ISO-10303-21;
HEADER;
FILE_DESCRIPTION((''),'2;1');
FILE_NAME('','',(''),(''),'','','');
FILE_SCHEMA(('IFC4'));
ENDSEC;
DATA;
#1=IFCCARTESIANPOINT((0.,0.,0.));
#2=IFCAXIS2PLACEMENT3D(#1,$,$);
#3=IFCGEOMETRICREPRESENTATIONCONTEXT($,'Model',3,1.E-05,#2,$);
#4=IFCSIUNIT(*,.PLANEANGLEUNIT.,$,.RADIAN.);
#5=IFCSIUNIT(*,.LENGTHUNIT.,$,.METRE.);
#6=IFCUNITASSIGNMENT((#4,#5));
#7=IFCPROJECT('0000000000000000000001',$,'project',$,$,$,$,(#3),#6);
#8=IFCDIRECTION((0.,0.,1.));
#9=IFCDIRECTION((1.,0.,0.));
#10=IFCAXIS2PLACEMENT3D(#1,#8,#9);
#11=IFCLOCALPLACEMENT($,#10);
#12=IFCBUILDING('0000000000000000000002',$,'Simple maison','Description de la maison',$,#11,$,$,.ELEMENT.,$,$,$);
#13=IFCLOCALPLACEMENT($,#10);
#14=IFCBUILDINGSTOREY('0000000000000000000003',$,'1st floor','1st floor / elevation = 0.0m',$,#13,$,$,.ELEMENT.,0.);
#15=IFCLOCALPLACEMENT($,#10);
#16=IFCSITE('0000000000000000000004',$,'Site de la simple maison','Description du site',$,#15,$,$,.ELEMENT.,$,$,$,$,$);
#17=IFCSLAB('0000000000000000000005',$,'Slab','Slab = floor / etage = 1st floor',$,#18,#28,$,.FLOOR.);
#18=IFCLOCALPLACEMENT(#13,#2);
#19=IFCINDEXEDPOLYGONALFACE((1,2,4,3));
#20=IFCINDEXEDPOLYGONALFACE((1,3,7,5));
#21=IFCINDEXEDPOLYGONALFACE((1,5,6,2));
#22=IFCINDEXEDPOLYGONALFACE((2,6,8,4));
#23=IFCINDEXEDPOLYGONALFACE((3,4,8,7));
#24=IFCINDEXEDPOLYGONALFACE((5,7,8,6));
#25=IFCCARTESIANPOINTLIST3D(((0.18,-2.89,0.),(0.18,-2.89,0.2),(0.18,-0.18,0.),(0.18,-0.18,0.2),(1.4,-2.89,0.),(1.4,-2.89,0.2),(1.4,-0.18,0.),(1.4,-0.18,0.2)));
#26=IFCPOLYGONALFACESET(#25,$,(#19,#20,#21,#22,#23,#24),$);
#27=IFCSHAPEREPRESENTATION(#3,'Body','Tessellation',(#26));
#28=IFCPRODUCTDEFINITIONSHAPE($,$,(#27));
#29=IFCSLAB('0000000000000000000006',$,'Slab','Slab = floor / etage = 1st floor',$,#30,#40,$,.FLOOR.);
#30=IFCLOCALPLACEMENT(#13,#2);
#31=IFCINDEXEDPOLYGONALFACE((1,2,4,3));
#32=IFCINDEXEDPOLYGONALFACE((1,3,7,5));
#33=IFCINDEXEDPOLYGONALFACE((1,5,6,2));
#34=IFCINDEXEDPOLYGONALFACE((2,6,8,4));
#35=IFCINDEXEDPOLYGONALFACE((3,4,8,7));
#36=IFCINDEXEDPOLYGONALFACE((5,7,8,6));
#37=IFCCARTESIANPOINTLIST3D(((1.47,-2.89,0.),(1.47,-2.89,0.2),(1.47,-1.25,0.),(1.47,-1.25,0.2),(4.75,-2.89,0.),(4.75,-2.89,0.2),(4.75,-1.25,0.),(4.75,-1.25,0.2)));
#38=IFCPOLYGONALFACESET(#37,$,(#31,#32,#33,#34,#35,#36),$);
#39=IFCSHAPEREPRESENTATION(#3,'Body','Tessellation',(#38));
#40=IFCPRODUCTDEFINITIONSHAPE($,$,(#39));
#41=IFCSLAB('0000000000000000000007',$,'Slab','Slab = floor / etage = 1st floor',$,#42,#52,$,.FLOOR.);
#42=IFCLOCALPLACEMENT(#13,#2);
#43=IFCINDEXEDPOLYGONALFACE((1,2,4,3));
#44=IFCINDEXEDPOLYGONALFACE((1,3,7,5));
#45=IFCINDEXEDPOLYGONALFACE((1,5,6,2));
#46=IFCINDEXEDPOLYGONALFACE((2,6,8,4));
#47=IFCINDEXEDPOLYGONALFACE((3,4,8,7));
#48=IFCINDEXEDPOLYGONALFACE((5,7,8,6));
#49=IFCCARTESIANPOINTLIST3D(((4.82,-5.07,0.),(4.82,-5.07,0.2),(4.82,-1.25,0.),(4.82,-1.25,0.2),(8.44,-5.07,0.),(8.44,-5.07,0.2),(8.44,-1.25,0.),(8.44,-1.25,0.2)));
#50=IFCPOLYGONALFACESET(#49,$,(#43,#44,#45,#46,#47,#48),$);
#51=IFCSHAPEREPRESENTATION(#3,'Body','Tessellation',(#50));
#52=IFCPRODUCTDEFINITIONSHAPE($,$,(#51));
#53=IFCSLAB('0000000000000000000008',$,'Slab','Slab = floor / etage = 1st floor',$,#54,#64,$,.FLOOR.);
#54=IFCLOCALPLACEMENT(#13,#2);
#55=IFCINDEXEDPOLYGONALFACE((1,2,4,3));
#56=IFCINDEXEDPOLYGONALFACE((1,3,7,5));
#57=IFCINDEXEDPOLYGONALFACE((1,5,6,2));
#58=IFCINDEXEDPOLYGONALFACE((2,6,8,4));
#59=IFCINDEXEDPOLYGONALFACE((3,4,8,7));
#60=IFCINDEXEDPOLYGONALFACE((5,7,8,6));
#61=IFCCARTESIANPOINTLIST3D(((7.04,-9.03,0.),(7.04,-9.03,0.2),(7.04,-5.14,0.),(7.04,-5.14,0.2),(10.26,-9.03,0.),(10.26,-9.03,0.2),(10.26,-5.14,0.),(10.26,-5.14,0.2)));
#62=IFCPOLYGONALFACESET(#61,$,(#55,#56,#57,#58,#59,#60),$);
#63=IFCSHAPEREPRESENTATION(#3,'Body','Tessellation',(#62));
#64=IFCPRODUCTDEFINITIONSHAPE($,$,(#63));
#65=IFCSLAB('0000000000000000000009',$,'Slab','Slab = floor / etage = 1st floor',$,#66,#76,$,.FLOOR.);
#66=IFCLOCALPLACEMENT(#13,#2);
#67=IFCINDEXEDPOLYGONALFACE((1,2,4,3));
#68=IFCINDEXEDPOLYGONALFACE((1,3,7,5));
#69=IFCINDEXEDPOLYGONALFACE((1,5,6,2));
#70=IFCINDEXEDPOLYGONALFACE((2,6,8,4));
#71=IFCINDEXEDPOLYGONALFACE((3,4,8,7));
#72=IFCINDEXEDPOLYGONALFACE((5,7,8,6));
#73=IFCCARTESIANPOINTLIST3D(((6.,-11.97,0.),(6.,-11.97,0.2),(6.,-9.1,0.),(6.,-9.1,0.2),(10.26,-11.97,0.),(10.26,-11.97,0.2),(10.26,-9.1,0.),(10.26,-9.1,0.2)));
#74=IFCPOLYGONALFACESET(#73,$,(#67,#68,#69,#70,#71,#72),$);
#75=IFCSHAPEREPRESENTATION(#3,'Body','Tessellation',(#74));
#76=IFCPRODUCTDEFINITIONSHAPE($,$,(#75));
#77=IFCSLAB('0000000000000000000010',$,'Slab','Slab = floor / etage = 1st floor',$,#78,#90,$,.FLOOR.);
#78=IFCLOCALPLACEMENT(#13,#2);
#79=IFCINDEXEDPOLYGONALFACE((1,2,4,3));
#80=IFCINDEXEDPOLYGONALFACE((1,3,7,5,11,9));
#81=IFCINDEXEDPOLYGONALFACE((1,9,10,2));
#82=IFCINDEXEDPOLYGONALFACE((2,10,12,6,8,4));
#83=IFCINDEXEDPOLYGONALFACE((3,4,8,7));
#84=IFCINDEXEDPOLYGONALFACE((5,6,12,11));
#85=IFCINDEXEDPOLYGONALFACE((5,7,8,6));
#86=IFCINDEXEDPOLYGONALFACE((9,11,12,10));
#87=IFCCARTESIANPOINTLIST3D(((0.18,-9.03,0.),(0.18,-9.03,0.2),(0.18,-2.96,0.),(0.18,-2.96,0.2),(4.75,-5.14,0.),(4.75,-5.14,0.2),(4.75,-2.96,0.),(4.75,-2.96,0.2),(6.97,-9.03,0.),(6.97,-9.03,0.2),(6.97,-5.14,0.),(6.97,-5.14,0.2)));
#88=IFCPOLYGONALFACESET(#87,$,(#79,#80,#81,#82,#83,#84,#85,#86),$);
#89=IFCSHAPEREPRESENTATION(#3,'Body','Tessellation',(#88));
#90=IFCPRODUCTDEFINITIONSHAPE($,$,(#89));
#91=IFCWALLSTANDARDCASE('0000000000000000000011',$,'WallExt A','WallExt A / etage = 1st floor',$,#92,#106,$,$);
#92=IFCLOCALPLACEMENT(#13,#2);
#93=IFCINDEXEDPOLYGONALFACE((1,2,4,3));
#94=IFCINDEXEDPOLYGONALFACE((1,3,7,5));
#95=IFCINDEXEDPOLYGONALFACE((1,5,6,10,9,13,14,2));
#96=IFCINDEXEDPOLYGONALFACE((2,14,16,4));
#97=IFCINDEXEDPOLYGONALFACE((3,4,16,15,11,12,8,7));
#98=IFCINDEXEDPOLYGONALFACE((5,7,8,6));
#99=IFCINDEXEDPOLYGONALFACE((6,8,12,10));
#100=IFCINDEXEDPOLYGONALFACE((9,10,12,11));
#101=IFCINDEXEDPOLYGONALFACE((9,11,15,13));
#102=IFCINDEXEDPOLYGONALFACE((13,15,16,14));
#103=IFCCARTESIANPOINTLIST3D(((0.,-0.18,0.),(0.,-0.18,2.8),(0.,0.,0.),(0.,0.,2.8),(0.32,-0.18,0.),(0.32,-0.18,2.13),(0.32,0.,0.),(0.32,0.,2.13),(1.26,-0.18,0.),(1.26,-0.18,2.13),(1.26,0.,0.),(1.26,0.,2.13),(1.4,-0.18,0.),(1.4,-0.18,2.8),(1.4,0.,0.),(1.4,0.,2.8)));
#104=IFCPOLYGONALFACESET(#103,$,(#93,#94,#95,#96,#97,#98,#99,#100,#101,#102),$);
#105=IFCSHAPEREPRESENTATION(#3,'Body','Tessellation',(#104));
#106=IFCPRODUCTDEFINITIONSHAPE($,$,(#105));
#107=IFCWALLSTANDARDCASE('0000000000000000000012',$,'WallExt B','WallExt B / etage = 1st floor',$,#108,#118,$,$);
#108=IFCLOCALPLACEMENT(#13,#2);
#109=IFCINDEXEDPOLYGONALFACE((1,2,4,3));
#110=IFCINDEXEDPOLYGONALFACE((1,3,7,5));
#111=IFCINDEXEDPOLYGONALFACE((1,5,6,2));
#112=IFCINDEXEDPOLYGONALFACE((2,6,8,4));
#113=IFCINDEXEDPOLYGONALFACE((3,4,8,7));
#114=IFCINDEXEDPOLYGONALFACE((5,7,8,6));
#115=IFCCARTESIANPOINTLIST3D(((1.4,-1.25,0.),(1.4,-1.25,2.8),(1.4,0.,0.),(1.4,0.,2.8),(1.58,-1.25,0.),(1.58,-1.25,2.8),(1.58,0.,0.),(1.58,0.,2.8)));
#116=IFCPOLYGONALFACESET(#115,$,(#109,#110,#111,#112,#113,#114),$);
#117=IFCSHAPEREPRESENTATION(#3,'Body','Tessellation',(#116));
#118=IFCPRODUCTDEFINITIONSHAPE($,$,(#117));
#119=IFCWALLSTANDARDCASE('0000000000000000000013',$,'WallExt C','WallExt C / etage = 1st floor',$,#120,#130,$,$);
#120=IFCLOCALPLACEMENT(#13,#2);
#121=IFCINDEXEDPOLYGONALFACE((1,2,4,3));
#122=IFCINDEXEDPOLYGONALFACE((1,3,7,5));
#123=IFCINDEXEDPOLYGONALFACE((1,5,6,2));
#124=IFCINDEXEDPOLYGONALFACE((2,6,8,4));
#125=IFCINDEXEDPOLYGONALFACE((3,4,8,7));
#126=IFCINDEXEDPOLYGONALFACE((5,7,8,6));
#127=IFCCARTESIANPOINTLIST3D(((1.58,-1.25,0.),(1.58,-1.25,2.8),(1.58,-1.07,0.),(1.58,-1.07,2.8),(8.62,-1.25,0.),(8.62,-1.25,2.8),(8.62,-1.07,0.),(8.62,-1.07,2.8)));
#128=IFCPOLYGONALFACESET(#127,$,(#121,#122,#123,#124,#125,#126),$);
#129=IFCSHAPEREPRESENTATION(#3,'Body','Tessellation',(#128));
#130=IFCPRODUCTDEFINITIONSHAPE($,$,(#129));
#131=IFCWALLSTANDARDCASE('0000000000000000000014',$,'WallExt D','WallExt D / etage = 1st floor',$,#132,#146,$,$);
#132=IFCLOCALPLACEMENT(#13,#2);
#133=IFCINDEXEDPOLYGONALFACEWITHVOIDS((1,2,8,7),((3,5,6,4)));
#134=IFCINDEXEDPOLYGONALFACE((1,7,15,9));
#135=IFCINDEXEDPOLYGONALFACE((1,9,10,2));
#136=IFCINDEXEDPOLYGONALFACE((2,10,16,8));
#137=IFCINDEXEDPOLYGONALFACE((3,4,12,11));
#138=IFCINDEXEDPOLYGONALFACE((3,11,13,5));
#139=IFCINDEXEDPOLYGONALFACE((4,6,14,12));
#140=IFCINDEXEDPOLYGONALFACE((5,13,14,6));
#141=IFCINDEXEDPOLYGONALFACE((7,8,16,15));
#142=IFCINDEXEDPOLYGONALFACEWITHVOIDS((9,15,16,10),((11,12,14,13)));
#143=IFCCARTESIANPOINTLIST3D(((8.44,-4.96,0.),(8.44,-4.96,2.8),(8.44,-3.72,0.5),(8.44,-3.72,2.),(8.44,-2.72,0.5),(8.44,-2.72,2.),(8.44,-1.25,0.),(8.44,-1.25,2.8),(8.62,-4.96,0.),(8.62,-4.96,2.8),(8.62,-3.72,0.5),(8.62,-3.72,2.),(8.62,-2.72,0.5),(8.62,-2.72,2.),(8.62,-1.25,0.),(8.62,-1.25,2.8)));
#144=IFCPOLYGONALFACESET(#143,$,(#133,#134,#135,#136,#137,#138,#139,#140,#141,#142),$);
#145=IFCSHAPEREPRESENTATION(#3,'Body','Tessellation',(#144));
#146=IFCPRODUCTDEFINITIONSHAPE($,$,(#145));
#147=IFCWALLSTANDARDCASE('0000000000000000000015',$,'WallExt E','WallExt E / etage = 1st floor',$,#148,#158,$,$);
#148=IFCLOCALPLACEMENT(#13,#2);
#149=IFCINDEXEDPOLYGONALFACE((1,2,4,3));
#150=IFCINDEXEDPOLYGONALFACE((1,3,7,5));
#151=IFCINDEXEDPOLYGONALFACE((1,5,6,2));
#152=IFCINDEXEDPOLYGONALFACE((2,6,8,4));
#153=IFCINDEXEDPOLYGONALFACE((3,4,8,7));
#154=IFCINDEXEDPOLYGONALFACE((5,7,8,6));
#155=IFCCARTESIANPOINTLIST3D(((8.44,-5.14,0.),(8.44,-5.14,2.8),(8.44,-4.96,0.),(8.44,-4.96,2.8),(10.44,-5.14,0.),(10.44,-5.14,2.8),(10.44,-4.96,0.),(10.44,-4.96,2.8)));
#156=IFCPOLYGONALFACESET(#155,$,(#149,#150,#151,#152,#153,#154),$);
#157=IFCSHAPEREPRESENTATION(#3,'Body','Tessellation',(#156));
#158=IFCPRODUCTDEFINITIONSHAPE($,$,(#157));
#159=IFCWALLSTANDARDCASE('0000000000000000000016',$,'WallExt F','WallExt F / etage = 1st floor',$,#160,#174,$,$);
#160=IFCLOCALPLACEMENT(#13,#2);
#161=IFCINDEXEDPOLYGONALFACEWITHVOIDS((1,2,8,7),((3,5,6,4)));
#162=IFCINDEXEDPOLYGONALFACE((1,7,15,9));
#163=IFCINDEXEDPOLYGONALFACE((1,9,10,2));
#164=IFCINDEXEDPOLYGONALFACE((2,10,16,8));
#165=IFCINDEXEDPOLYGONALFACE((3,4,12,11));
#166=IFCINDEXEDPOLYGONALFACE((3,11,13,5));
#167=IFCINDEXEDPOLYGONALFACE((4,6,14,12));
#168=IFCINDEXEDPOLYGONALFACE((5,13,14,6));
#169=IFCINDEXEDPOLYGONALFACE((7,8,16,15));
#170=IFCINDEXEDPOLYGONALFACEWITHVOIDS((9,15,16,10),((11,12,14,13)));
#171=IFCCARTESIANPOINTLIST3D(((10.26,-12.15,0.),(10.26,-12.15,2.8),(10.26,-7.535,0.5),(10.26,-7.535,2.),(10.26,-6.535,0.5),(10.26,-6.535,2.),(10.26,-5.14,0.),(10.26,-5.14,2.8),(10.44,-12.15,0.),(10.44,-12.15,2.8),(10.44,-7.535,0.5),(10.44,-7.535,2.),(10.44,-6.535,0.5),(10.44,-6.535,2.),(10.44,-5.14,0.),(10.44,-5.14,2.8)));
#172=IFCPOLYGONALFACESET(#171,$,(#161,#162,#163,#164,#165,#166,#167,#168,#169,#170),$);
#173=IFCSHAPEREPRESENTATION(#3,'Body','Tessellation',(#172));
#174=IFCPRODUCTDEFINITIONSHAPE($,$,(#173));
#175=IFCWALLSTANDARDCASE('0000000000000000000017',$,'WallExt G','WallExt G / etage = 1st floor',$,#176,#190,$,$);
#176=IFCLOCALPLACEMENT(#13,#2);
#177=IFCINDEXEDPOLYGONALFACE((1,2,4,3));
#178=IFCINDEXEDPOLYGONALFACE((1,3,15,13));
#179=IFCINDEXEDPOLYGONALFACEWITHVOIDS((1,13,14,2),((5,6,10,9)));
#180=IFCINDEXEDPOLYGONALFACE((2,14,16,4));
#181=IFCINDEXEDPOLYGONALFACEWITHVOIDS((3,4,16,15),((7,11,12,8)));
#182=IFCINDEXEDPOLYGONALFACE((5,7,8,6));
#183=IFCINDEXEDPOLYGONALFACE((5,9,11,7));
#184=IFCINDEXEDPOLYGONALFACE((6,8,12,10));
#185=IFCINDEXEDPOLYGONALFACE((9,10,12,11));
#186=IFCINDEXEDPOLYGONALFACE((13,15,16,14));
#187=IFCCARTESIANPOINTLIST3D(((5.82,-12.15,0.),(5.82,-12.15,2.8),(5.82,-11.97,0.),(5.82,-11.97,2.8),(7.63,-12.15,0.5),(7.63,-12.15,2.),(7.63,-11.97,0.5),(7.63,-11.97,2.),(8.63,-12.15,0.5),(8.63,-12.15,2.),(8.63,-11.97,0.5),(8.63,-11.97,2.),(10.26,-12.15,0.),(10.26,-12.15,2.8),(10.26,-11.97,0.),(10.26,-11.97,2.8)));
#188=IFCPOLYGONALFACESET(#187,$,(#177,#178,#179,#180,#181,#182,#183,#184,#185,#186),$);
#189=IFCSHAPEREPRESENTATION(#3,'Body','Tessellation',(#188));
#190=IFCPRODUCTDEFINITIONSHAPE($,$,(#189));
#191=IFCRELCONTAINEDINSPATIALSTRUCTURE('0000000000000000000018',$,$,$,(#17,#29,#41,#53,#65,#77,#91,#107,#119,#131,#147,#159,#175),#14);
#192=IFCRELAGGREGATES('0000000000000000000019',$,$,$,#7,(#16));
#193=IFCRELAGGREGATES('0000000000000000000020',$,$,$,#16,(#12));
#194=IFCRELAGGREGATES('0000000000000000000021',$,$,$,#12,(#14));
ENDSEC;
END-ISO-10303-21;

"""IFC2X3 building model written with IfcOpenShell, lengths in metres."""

from ifc_helpers import new_model, si_unit, frame, origin, origin_with_axes, origin_2d_with_axis, place, context, project, spatial, polyline, rectangle, outline, extrude, element, save


model = new_model("IFC2X3")

# Units and contexts
model_context = context("Model", 3, precision=1e-05, world=origin())
ifc_project = project(units=[si_unit("PLANEANGLEUNIT", "RADIAN"), si_unit("LENGTHUNIT", "METRE")], contexts=[model_context])

# Site, building, storey
site_placement = place(None, origin_with_axes())
site = spatial("IfcSite", under=ifc_project, at=site_placement, Name="Site de la simple maison", Description="Description du site", CompositionType="ELEMENT")
building_placement = place(None, origin_with_axes())
building = spatial("IfcBuilding", under=site, at=building_placement, Name="Simple maison", Description="Description de la maison", CompositionType="ELEMENT")
storey_placement = place(None, origin_with_axes())
storey = spatial("IfcBuildingStorey", under=building, at=storey_placement, Name="1st floor", Description="1st floor / elevation = 0.0m", CompositionType="ELEMENT", Elevation=0.0)

# Slabs
slab_1_placement = place(storey_placement, origin_with_axes())
element("IfcSlab", 1, at=slab_1_placement, inside=storey, Name="Slab", Description="Slab = floor / etage = 1st floor", PredefinedType="FLOOR", context=model_context, shape_type="SweptSolid", body=[
    extrude(outline(polyline([(0.18, -0.18), (1.4, -0.18), (1.4, -2.89), (0.18, -2.89), (0.18, -0.18)])), origin(), (0.0, 0.0, 1.0), 0.2),
])
slab_2_placement = place(storey_placement, origin_with_axes())
element("IfcSlab", 2, at=slab_2_placement, inside=storey, Name="Slab", Description="Slab = floor / etage = 1st floor", PredefinedType="FLOOR", context=model_context, shape_type="SweptSolid", body=[
    extrude(outline(polyline([(1.47, -1.25), (4.75, -1.25), (4.75, -2.89), (1.47, -2.89), (1.47, -1.25)])), origin(), (0.0, 0.0, 1.0), 0.2),
])
slab_3_placement = place(storey_placement, origin_with_axes())
element("IfcSlab", 3, at=slab_3_placement, inside=storey, Name="Slab", Description="Slab = floor / etage = 1st floor", PredefinedType="FLOOR", context=model_context, shape_type="SweptSolid", body=[
    extrude(outline(polyline([(4.82, -1.25), (8.44, -1.25), (8.44, -5.07), (4.82, -5.07), (4.82, -1.25)])), origin(), (0.0, 0.0, 1.0), 0.2),
])
slab_4_placement = place(storey_placement, origin_with_axes())
element("IfcSlab", 4, at=slab_4_placement, inside=storey, Name="Slab", Description="Slab = floor / etage = 1st floor", PredefinedType="FLOOR", context=model_context, shape_type="SweptSolid", body=[
    extrude(outline(polyline([(7.04, -5.14), (10.26, -5.14), (10.26, -9.03), (7.04, -9.03), (7.04, -5.14)])), origin(), (0.0, 0.0, 1.0), 0.2),
])
slab_5_placement = place(storey_placement, origin_with_axes())
element("IfcSlab", 5, at=slab_5_placement, inside=storey, Name="Slab", Description="Slab = floor / etage = 1st floor", PredefinedType="FLOOR", context=model_context, shape_type="SweptSolid", body=[
    extrude(outline(polyline([(6.0, -9.1), (10.26, -9.1), (10.26, -11.97), (6.0, -11.97), (6.0, -9.1)])), origin(), (0.0, 0.0, 1.0), 0.2),
])
slab_6_placement = place(storey_placement, origin_with_axes())
element("IfcSlab", 6, at=slab_6_placement, inside=storey, Name="Slab", Description="Slab = floor / etage = 1st floor", PredefinedType="FLOOR", context=model_context, shape_type="SweptSolid", body=[
    extrude(outline(polyline([(0.18, -2.96), (4.75, -2.96), (4.75, -5.14), (6.97, -5.14), (6.97, -9.03), (0.18, -9.03), (0.18, -2.96)])), origin(), (0.0, 0.0, 1.0), 0.2),
])

# Wall, opening
wall_1_placement = place(storey_placement, frame((0.0, -0.09, 0.0), z_axis=(0.0, 0.0, 1.0), x_axis=(1.0, 0.0, 0.0)))
wall_1 = element("IfcWallStandardCase", 7, at=wall_1_placement, inside=storey, Name="WallExt A", Description="WallExt A / etage = 1st floor", context=model_context, shape_type="SweptSolid", body=[
    extrude(outline(polyline([(0.0, 0.09), (1.4, 0.09), (1.4, -0.09), (0.0, -0.09), (0.0, 0.09)])), origin(), (0.0, 0.0, 1.0), 2.8),
])
opening_1_placement = place(wall_1_placement, frame((0.32, -0.09, 0.0), z_axis=(0.0, 0.0, 1.0), x_axis=(1.0, 0.0, 0.0)))
element("IfcOpeningElement", 8, at=opening_1_placement, cuts=wall_1, context=model_context, shape_type="SweptSolid", body=[
    extrude(rectangle(XDim=2.13, YDim=0.94, at=origin_2d_with_axis()), frame((0.47, 0.0, 1.065), z_axis=(0.0, 1.0, 0.0), x_axis=(0.0, 0.0, 1.0)), (0.0, 0.0, 1.0), 0.18),
])

# Walls
wall_2_placement = place(storey_placement, frame((1.49, 0.0, 0.0), z_axis=(0.0, 0.0, 1.0), x_axis=(0.0, -1.0, 0.0)))
element("IfcWallStandardCase", 9, at=wall_2_placement, inside=storey, Name="WallExt B", Description="WallExt B / etage = 1st floor", context=model_context, shape_type="SweptSolid", body=[
    extrude(outline(polyline([(0.0, 0.09), (1.25, 0.09), (1.25, -0.09), (0.0, -0.09), (0.0, 0.09)])), origin(), (0.0, 0.0, 1.0), 2.8),
])
wall_3_placement = place(storey_placement, frame((1.58, -1.16, 0.0), z_axis=(0.0, 0.0, 1.0), x_axis=(1.0, 0.0, 0.0)))
element("IfcWallStandardCase", 10, at=wall_3_placement, inside=storey, Name="WallExt C", Description="WallExt C / etage = 1st floor", context=model_context, shape_type="SweptSolid", body=[
    extrude(outline(polyline([(0.0, 0.09), (7.04, 0.09), (7.04, -0.09), (0.0, -0.09), (0.0, 0.09)])), origin(), (0.0, 0.0, 1.0), 2.8),
])

# Wall, opening
wall_4_placement = place(storey_placement, frame((8.53, -1.25, 0.0), z_axis=(0.0, 0.0, 1.0), x_axis=(0.0, -1.0, 0.0)))
wall_4 = element("IfcWallStandardCase", 11, at=wall_4_placement, inside=storey, Name="WallExt D", Description="WallExt D / etage = 1st floor", context=model_context, shape_type="SweptSolid", body=[
    extrude(outline(polyline([(0.0, 0.09), (3.71, 0.09), (3.71, -0.09), (0.0, -0.09), (0.0, 0.09)])), origin(), (0.0, 0.0, 1.0), 2.8),
])
opening_2_placement = place(wall_4_placement, frame((1.47, -0.09, 0.5), z_axis=(0.0, 0.0, 1.0), x_axis=(1.0, 0.0, 0.0)))
element("IfcOpeningElement", 12, at=opening_2_placement, cuts=wall_4, context=model_context, shape_type="SweptSolid", body=[
    extrude(rectangle(XDim=1.5, YDim=1.0, at=origin_2d_with_axis()), frame((0.5, 0.0, 0.75), z_axis=(0.0, 1.0, 0.0), x_axis=(0.0, 0.0, 1.0)), (0.0, 0.0, 1.0), 0.18),
])

# Wall
wall_5_placement = place(storey_placement, frame((8.44, -5.05, 0.0), z_axis=(0.0, 0.0, 1.0), x_axis=(1.0, 0.0, 0.0)))
element("IfcWallStandardCase", 13, at=wall_5_placement, inside=storey, Name="WallExt E", Description="WallExt E / etage = 1st floor", context=model_context, shape_type="SweptSolid", body=[
    extrude(outline(polyline([(0.0, 0.09), (2.0, 0.09), (2.0, -0.09), (0.0, -0.09), (0.0, 0.09)])), origin(), (0.0, 0.0, 1.0), 2.8),
])

# Walls, openings
wall_6_placement = place(storey_placement, frame((10.35, -5.14, 0.0), z_axis=(0.0, 0.0, 1.0), x_axis=(0.0, -1.0, 0.0)))
wall_6 = element("IfcWallStandardCase", 14, at=wall_6_placement, inside=storey, Name="WallExt F", Description="WallExt F / etage = 1st floor", context=model_context, shape_type="SweptSolid", body=[
    extrude(outline(polyline([(0.0, 0.09), (7.01, 0.09), (7.01, -0.09), (0.0, -0.09), (0.0, 0.09)])), origin(), (0.0, 0.0, 1.0), 2.8),
])
opening_3_placement = place(wall_6_placement, frame((1.395, -0.09, 0.5), z_axis=(0.0, 0.0, 1.0), x_axis=(1.0, 0.0, 0.0)))
element("IfcOpeningElement", 15, at=opening_3_placement, cuts=wall_6, context=model_context, shape_type="SweptSolid", body=[
    extrude(rectangle(XDim=1.5, YDim=1.0, at=origin_2d_with_axis()), frame((0.5, 0.0, 0.75), z_axis=(0.0, 1.0, 0.0), x_axis=(0.0, 0.0, 1.0)), (0.0, 0.0, 1.0), 0.18),
])
wall_7_placement = place(storey_placement, frame((10.26, -12.06, 0.0), z_axis=(0.0, 0.0, 1.0), x_axis=(-1.0, 0.0, 0.0)))
wall_7 = element("IfcWallStandardCase", 16, at=wall_7_placement, inside=storey, Name="WallExt G", Description="WallExt G / etage = 1st floor", context=model_context, shape_type="SweptSolid", body=[
    extrude(outline(polyline([(0.0, 0.09), (4.44, 0.09), (4.44, -0.09), (0.0, -0.09), (0.0, 0.09)])), origin(), (0.0, 0.0, 1.0), 2.8),
])
opening_4_placement = place(wall_7_placement, frame((1.63, -0.09, 0.5), z_axis=(0.0, 0.0, 1.0), x_axis=(1.0, 0.0, 0.0)))
element("IfcOpeningElement", 17, at=opening_4_placement, cuts=wall_7, context=model_context, shape_type="SweptSolid", body=[
    extrude(rectangle(XDim=1.5, YDim=1.0, at=origin_2d_with_axis()), frame((0.5, 0.0, 0.75), z_axis=(0.0, 1.0, 0.0), x_axis=(0.0, 0.0, 1.0)), (0.0, 0.0, 1.0), 0.18),
])

save(model, "model.ifc")
